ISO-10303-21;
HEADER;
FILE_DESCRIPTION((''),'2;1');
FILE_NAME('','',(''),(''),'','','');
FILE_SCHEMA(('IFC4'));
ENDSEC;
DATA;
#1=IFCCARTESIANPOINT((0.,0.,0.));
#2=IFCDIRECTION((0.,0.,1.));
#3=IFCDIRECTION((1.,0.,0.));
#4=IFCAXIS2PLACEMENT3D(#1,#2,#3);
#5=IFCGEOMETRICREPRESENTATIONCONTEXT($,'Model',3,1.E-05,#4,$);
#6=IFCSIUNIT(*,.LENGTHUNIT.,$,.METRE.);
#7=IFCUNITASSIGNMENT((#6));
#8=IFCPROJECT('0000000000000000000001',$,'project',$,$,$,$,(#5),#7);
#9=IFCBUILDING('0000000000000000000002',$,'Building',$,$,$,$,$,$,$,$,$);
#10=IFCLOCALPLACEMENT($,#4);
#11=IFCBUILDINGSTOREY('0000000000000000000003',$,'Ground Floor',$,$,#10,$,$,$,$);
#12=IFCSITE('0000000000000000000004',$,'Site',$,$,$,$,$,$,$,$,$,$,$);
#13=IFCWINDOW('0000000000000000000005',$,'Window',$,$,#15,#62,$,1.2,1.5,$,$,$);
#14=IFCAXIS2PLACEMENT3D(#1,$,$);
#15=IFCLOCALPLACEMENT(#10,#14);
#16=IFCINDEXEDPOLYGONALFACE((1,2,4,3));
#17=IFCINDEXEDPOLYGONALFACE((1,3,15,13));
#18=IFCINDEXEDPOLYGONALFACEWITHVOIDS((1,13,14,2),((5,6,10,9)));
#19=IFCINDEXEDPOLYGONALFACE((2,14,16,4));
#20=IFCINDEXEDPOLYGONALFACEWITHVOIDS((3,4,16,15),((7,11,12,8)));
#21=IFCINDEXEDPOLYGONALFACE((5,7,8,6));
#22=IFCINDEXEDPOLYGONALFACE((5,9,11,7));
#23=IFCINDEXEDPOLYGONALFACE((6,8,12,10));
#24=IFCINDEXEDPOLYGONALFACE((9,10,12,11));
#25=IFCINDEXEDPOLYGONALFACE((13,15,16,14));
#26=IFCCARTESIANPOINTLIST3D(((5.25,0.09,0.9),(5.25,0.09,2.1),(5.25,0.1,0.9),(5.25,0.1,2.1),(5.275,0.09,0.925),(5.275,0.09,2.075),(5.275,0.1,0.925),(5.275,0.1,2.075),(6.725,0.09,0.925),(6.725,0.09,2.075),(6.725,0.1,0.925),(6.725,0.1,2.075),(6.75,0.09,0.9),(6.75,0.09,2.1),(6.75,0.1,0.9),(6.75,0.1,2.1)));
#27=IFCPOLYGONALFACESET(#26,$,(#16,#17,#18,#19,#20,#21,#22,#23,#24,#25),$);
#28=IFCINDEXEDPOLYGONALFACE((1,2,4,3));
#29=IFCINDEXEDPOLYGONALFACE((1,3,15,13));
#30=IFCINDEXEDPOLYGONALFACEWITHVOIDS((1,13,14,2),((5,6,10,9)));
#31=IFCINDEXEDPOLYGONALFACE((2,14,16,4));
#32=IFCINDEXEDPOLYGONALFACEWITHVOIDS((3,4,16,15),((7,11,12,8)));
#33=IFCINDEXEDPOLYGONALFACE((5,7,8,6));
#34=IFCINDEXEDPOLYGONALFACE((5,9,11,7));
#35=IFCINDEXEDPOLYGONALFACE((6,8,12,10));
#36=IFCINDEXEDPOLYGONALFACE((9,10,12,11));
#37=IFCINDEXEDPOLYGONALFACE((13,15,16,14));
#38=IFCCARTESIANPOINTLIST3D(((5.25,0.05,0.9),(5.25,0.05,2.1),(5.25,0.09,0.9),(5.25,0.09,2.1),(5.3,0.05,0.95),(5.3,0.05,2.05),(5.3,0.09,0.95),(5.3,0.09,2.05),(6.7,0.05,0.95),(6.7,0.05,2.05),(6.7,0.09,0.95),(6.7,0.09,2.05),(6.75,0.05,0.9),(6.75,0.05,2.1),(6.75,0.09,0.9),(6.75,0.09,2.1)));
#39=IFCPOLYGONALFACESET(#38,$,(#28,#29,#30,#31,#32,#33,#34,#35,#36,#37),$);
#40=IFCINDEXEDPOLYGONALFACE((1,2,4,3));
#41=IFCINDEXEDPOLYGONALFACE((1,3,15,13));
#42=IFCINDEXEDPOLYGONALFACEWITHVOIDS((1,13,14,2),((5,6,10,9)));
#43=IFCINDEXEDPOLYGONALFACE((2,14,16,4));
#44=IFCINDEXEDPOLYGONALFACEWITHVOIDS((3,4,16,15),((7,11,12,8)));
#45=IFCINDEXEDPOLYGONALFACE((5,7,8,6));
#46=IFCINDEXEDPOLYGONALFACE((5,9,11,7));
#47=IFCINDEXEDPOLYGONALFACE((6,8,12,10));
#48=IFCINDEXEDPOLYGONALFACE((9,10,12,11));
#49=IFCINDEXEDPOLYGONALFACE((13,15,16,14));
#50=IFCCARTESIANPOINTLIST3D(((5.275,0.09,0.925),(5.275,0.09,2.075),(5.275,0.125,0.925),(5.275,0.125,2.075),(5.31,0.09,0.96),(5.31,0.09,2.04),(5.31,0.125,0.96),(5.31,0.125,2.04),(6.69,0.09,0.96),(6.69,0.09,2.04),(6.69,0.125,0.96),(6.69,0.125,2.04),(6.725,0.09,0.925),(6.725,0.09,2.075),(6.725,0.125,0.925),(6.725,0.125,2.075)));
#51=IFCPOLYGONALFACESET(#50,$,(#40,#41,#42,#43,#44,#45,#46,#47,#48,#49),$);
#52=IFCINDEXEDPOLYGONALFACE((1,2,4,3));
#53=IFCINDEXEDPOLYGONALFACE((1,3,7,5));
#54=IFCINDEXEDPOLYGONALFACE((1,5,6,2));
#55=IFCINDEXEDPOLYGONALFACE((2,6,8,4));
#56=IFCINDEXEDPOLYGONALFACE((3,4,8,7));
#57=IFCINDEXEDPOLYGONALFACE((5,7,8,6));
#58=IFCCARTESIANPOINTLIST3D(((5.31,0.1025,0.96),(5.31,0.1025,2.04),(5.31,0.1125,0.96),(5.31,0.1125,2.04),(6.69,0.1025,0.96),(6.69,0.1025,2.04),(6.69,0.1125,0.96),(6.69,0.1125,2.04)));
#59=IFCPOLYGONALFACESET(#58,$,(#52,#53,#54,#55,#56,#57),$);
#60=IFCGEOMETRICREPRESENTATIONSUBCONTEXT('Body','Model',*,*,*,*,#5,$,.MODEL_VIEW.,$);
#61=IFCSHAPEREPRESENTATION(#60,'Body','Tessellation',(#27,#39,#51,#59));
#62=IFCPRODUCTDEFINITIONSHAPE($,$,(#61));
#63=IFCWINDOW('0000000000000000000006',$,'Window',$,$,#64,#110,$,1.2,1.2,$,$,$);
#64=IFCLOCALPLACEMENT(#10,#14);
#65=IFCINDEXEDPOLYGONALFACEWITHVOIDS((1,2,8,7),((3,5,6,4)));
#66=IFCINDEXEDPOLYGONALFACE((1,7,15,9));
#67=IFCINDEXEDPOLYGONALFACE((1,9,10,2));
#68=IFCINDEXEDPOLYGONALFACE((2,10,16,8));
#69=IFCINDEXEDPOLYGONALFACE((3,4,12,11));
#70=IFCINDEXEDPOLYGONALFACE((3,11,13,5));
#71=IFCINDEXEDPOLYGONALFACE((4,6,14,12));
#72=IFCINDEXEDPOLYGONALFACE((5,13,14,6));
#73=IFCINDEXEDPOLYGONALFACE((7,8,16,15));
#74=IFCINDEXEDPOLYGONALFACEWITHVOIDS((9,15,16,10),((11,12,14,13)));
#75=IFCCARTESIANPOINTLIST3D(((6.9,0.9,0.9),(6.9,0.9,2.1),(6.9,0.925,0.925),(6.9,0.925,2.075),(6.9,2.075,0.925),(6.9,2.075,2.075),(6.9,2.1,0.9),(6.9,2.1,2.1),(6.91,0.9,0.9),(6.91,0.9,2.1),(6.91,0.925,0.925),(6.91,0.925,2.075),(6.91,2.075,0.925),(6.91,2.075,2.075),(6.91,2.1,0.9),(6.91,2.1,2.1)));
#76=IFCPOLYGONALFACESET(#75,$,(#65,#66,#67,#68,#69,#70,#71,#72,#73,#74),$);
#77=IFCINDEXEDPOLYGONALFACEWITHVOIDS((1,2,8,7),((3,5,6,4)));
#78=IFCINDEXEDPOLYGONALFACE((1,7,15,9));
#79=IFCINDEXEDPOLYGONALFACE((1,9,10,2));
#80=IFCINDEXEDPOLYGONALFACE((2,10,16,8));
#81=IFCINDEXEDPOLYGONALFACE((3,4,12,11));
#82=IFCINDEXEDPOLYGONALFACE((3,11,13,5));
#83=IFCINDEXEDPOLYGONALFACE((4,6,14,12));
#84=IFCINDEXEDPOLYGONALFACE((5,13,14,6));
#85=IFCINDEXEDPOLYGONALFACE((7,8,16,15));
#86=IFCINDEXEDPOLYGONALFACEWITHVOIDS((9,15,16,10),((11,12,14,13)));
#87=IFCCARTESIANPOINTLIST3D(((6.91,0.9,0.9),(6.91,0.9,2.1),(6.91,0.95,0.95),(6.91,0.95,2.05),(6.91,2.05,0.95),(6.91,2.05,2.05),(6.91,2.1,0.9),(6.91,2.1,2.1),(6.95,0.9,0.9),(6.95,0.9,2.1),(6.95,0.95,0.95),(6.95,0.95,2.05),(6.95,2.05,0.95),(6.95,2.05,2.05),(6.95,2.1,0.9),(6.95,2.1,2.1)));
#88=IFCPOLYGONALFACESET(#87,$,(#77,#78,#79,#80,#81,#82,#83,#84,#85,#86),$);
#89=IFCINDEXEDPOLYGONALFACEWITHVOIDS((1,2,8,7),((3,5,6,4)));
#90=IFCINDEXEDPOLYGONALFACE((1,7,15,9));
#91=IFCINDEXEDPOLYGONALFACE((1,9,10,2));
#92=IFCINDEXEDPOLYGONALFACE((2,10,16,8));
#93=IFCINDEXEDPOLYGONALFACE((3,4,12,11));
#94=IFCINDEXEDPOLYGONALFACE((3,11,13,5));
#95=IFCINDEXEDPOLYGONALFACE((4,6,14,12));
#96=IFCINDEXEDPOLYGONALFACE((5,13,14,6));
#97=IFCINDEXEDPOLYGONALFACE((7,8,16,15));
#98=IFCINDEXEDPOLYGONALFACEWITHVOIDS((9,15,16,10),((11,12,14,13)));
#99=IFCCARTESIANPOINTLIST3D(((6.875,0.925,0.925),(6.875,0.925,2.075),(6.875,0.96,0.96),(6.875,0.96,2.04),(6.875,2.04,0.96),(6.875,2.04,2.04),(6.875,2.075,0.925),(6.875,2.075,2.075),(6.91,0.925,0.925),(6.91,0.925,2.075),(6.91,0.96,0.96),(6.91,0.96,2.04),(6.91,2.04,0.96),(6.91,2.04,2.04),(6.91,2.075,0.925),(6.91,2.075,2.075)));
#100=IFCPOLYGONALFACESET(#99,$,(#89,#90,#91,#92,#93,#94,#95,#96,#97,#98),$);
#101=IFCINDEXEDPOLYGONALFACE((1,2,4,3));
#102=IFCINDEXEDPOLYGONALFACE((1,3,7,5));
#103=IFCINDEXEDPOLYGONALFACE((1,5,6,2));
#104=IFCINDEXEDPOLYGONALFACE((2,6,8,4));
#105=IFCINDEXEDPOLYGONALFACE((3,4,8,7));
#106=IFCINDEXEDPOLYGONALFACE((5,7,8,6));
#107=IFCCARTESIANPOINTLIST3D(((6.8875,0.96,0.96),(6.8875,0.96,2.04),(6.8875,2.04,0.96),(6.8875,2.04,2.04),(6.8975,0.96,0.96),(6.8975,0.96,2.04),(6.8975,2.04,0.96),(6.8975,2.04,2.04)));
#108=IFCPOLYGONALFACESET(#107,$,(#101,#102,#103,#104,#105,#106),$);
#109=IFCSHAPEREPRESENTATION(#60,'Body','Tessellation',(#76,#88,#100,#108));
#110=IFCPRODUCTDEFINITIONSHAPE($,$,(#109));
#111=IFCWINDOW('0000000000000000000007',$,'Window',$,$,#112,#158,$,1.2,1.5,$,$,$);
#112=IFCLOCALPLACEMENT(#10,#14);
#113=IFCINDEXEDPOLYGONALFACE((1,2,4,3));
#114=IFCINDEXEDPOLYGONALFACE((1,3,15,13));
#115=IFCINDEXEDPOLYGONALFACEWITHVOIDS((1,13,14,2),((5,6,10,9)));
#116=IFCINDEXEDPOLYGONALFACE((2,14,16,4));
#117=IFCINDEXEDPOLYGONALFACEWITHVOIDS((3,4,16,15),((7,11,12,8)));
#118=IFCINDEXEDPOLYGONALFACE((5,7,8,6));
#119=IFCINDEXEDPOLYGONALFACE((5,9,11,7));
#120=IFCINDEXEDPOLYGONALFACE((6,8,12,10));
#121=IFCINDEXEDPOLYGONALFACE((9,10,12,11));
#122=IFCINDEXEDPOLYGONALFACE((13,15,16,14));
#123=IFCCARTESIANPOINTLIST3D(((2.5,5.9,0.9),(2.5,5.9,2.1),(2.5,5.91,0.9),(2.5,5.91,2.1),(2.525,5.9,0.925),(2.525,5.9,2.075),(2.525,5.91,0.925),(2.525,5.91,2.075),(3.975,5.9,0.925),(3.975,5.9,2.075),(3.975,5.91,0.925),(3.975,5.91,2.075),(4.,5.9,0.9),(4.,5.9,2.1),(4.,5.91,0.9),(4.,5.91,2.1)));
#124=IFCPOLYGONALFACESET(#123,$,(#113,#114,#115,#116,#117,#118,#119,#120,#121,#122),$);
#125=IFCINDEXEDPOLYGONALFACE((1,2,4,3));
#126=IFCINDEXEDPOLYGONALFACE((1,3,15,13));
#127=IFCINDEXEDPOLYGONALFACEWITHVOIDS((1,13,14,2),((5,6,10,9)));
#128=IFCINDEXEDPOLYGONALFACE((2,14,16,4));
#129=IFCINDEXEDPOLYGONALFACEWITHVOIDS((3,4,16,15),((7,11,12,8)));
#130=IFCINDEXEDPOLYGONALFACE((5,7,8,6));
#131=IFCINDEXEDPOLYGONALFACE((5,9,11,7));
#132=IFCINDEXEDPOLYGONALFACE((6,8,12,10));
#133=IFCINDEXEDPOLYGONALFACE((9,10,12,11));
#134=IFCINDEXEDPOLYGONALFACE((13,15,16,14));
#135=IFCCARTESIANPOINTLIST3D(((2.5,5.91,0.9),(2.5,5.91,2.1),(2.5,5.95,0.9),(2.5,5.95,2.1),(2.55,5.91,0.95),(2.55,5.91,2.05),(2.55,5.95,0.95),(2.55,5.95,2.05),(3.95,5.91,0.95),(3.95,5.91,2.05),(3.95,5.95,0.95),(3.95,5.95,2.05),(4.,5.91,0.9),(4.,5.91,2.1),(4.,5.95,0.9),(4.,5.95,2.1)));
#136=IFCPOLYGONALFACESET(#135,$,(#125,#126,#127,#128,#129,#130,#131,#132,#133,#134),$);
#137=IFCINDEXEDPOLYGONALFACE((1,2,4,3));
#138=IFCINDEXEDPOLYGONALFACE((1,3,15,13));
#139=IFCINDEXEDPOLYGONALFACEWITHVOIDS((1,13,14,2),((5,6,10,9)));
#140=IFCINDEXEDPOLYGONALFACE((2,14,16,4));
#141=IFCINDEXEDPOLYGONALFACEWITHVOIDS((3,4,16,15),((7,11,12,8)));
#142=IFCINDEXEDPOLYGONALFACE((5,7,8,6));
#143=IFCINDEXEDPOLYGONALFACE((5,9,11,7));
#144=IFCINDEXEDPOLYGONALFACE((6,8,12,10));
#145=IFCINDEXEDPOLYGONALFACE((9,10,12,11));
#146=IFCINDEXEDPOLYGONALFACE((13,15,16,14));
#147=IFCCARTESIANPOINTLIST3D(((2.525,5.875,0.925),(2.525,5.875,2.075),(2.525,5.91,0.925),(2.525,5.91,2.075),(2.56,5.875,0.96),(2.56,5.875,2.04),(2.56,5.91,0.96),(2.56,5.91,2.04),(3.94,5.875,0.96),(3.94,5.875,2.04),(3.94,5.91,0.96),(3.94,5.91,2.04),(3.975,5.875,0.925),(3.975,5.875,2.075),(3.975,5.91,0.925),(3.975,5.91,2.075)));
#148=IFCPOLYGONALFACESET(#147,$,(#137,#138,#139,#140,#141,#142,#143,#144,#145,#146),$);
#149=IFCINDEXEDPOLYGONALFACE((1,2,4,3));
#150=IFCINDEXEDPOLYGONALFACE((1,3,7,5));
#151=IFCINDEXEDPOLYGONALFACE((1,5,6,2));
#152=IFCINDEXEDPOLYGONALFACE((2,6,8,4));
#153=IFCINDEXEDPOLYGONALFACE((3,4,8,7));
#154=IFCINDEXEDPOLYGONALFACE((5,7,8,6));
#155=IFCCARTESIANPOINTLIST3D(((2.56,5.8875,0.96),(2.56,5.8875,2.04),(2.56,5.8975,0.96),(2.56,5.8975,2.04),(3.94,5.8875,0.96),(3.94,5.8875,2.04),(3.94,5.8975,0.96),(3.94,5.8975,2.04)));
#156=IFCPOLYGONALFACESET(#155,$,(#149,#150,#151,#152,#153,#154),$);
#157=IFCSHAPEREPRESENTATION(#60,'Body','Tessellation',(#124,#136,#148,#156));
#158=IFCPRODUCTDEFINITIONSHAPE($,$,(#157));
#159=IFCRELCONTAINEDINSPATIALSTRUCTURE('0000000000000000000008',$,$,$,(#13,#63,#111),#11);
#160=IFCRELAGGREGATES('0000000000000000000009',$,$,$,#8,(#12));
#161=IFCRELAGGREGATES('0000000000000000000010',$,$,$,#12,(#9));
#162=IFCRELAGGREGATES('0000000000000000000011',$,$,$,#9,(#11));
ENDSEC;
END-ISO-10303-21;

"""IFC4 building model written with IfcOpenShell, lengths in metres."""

from ifc_helpers import new_model, si_unit, frame, origin_with_axes, place, context, subcontext, project, spatial, line, indexed_curve, outline, extrude, element, save


model = new_model("IFC4")

# Units and contexts
model_context = context("Model", 3, precision=1e-05, world=origin_with_axes())
body_context = subcontext(model_context, "Body", "Model", "MODEL_VIEW")
ifc_project = project(units=[si_unit("LENGTHUNIT", "METRE")], contexts=[model_context])

# Site, building, storey
site = spatial("IfcSite", under=ifc_project, Name="Site")
building = spatial("IfcBuilding", under=site, Name="Building")
storey_placement = place(None, origin_with_axes())
storey = spatial("IfcBuildingStorey", under=building, at=storey_placement, Name="Ground Floor")

# Windows
window_1_placement = place(storey_placement, frame((5.25, 0.0, 0.9), z_axis=(0.0, 0.0, 1.0), x_axis=(1.0, 0.0, 0.0)))
element("IfcWindow", 1, at=window_1_placement, inside=storey, Name="Window", OverallHeight=1.2, OverallWidth=1.5, context=body_context, shape_type="SweptSolid", body=[
    extrude(outline(indexed_curve([(0.0, 0.0), (1.5, 0.0), (1.5, 1.2), (0.0, 1.2)], segments=[line(1, 2, 3, 4, 1)]), holes=[indexed_curve([(0.025, 0.025), (1.475, 0.025), (1.475, 1.175), (0.025, 1.175)], segments=[line(1, 2, 3, 4, 1)])]), frame((0.0, 0.09, 0.0), z_axis=(0.0, -1.0, 0.0), x_axis=(1.0, 0.0, 0.0)), (0.0, 0.0, -1.0), 0.01),
    extrude(outline(indexed_curve([(0.0, 0.0), (1.5, 0.0), (1.5, 1.2), (0.0, 1.2)], segments=[line(1, 2, 3, 4, 1)]), holes=[indexed_curve([(0.05, 0.05), (1.45, 0.05), (1.45, 1.15), (0.05, 1.15)], segments=[line(1, 2, 3, 4, 1)])]), frame((0.0, 0.05, 0.0), z_axis=(0.0, -1.0, 0.0), x_axis=(1.0, 0.0, 0.0)), (0.0, 0.0, -1.0), 0.04),
    extrude(outline(indexed_curve([(0.0, 0.0), (1.45, 0.0), (1.45, 1.15), (0.0, 1.15)], segments=[line(1, 2, 3, 4, 1)]), holes=[indexed_curve([(0.035, 0.035), (1.415, 0.035), (1.415, 1.115), (0.035, 1.115)], segments=[line(1, 2, 3, 4, 1)])]), frame((0.025, 0.09, 0.025), z_axis=(0.0, -1.0, 0.0), x_axis=(1.0, 0.0, 0.0)), (0.0, 0.0, -1.0), 0.035),
    extrude(outline(indexed_curve([(0.035, 0.035), (1.415, 0.035), (1.415, 1.115), (0.035, 1.115)], segments=[line(1, 2, 3, 4, 1)])), frame((0.025, 0.1025, 0.025), z_axis=(0.0, -1.0, 0.0), x_axis=(1.0, 0.0, 0.0)), (0.0, 0.0, -1.0), 0.01),
])
window_2_placement = place(storey_placement, frame((7.0, 0.9, 0.9), z_axis=(0.0, 0.0, 1.0), x_axis=(0.0, 1.0, 0.0)))
element("IfcWindow", 2, at=window_2_placement, inside=storey, Name="Window", OverallHeight=1.2, OverallWidth=1.2, context=body_context, shape_type="SweptSolid", body=[
    extrude(outline(indexed_curve([(0.0, 0.0), (1.2, 0.0), (1.2, 1.2), (0.0, 1.2)], segments=[line(1, 2, 3, 4, 1)]), holes=[indexed_curve([(0.025, 0.025), (1.175, 0.025), (1.175, 1.175), (0.025, 1.175)], segments=[line(1, 2, 3, 4, 1)])]), frame((0.0, 0.09, 0.0), z_axis=(0.0, -1.0, 0.0), x_axis=(1.0, 0.0, 0.0)), (0.0, 0.0, -1.0), 0.01),
    extrude(outline(indexed_curve([(0.0, 0.0), (1.2, 0.0), (1.2, 1.2), (0.0, 1.2)], segments=[line(1, 2, 3, 4, 1)]), holes=[indexed_curve([(0.05, 0.05), (1.15, 0.05), (1.15, 1.15), (0.05, 1.15)], segments=[line(1, 2, 3, 4, 1)])]), frame((0.0, 0.05, 0.0), z_axis=(0.0, -1.0, 0.0), x_axis=(1.0, 0.0, 0.0)), (0.0, 0.0, -1.0), 0.04),
    extrude(outline(indexed_curve([(0.0, 0.0), (1.15, 0.0), (1.15, 1.15), (0.0, 1.15)], segments=[line(1, 2, 3, 4, 1)]), holes=[indexed_curve([(0.035, 0.035), (1.115, 0.035), (1.115, 1.115), (0.035, 1.115)], segments=[line(1, 2, 3, 4, 1)])]), frame((0.025, 0.09, 0.025), z_axis=(0.0, -1.0, 0.0), x_axis=(1.0, 0.0, 0.0)), (0.0, 0.0, -1.0), 0.035),
    extrude(outline(indexed_curve([(0.035, 0.035), (1.115, 0.035), (1.115, 1.115), (0.035, 1.115)], segments=[line(1, 2, 3, 4, 1)])), frame((0.025, 0.1025, 0.025), z_axis=(0.0, -1.0, 0.0), x_axis=(1.0, 0.0, 0.0)), (0.0, 0.0, -1.0), 0.01),
])
window_3_placement = place(storey_placement, frame((4.0, 6.0, 0.9), z_axis=(0.0, 0.0, 1.0), x_axis=(-1.0, 0.0, 0.0)))
element("IfcWindow", 3, at=window_3_placement, inside=storey, Name="Window", OverallHeight=1.2, OverallWidth=1.5, context=body_context, shape_type="SweptSolid", body=[
    extrude(outline(indexed_curve([(0.0, 0.0), (1.5, 0.0), (1.5, 1.2), (0.0, 1.2)], segments=[line(1, 2, 3, 4, 1)]), holes=[indexed_curve([(0.025, 0.025), (1.475, 0.025), (1.475, 1.175), (0.025, 1.175)], segments=[line(1, 2, 3, 4, 1)])]), frame((0.0, 0.09, 0.0), z_axis=(0.0, -1.0, 0.0), x_axis=(1.0, 0.0, 0.0)), (0.0, 0.0, -1.0), 0.01),
    extrude(outline(indexed_curve([(0.0, 0.0), (1.5, 0.0), (1.5, 1.2), (0.0, 1.2)], segments=[line(1, 2, 3, 4, 1)]), holes=[indexed_curve([(0.05, 0.05), (1.45, 0.05), (1.45, 1.15), (0.05, 1.15)], segments=[line(1, 2, 3, 4, 1)])]), frame((0.0, 0.05, 0.0), z_axis=(0.0, -1.0, 0.0), x_axis=(1.0, 0.0, 0.0)), (0.0, 0.0, -1.0), 0.04),
    extrude(outline(indexed_curve([(0.0, 0.0), (1.45, 0.0), (1.45, 1.15), (0.0, 1.15)], segments=[line(1, 2, 3, 4, 1)]), holes=[indexed_curve([(0.035, 0.035), (1.415, 0.035), (1.415, 1.115), (0.035, 1.115)], segments=[line(1, 2, 3, 4, 1)])]), frame((0.025, 0.09, 0.025), z_axis=(0.0, -1.0, 0.0), x_axis=(1.0, 0.0, 0.0)), (0.0, 0.0, -1.0), 0.035),
    extrude(outline(indexed_curve([(0.035, 0.035), (1.415, 0.035), (1.415, 1.115), (0.035, 1.115)], segments=[line(1, 2, 3, 4, 1)])), frame((0.025, 0.1025, 0.025), z_axis=(0.0, -1.0, 0.0), x_axis=(1.0, 0.0, 0.0)), (0.0, 0.0, -1.0), 0.01),
])

save(model, "model.ifc")
